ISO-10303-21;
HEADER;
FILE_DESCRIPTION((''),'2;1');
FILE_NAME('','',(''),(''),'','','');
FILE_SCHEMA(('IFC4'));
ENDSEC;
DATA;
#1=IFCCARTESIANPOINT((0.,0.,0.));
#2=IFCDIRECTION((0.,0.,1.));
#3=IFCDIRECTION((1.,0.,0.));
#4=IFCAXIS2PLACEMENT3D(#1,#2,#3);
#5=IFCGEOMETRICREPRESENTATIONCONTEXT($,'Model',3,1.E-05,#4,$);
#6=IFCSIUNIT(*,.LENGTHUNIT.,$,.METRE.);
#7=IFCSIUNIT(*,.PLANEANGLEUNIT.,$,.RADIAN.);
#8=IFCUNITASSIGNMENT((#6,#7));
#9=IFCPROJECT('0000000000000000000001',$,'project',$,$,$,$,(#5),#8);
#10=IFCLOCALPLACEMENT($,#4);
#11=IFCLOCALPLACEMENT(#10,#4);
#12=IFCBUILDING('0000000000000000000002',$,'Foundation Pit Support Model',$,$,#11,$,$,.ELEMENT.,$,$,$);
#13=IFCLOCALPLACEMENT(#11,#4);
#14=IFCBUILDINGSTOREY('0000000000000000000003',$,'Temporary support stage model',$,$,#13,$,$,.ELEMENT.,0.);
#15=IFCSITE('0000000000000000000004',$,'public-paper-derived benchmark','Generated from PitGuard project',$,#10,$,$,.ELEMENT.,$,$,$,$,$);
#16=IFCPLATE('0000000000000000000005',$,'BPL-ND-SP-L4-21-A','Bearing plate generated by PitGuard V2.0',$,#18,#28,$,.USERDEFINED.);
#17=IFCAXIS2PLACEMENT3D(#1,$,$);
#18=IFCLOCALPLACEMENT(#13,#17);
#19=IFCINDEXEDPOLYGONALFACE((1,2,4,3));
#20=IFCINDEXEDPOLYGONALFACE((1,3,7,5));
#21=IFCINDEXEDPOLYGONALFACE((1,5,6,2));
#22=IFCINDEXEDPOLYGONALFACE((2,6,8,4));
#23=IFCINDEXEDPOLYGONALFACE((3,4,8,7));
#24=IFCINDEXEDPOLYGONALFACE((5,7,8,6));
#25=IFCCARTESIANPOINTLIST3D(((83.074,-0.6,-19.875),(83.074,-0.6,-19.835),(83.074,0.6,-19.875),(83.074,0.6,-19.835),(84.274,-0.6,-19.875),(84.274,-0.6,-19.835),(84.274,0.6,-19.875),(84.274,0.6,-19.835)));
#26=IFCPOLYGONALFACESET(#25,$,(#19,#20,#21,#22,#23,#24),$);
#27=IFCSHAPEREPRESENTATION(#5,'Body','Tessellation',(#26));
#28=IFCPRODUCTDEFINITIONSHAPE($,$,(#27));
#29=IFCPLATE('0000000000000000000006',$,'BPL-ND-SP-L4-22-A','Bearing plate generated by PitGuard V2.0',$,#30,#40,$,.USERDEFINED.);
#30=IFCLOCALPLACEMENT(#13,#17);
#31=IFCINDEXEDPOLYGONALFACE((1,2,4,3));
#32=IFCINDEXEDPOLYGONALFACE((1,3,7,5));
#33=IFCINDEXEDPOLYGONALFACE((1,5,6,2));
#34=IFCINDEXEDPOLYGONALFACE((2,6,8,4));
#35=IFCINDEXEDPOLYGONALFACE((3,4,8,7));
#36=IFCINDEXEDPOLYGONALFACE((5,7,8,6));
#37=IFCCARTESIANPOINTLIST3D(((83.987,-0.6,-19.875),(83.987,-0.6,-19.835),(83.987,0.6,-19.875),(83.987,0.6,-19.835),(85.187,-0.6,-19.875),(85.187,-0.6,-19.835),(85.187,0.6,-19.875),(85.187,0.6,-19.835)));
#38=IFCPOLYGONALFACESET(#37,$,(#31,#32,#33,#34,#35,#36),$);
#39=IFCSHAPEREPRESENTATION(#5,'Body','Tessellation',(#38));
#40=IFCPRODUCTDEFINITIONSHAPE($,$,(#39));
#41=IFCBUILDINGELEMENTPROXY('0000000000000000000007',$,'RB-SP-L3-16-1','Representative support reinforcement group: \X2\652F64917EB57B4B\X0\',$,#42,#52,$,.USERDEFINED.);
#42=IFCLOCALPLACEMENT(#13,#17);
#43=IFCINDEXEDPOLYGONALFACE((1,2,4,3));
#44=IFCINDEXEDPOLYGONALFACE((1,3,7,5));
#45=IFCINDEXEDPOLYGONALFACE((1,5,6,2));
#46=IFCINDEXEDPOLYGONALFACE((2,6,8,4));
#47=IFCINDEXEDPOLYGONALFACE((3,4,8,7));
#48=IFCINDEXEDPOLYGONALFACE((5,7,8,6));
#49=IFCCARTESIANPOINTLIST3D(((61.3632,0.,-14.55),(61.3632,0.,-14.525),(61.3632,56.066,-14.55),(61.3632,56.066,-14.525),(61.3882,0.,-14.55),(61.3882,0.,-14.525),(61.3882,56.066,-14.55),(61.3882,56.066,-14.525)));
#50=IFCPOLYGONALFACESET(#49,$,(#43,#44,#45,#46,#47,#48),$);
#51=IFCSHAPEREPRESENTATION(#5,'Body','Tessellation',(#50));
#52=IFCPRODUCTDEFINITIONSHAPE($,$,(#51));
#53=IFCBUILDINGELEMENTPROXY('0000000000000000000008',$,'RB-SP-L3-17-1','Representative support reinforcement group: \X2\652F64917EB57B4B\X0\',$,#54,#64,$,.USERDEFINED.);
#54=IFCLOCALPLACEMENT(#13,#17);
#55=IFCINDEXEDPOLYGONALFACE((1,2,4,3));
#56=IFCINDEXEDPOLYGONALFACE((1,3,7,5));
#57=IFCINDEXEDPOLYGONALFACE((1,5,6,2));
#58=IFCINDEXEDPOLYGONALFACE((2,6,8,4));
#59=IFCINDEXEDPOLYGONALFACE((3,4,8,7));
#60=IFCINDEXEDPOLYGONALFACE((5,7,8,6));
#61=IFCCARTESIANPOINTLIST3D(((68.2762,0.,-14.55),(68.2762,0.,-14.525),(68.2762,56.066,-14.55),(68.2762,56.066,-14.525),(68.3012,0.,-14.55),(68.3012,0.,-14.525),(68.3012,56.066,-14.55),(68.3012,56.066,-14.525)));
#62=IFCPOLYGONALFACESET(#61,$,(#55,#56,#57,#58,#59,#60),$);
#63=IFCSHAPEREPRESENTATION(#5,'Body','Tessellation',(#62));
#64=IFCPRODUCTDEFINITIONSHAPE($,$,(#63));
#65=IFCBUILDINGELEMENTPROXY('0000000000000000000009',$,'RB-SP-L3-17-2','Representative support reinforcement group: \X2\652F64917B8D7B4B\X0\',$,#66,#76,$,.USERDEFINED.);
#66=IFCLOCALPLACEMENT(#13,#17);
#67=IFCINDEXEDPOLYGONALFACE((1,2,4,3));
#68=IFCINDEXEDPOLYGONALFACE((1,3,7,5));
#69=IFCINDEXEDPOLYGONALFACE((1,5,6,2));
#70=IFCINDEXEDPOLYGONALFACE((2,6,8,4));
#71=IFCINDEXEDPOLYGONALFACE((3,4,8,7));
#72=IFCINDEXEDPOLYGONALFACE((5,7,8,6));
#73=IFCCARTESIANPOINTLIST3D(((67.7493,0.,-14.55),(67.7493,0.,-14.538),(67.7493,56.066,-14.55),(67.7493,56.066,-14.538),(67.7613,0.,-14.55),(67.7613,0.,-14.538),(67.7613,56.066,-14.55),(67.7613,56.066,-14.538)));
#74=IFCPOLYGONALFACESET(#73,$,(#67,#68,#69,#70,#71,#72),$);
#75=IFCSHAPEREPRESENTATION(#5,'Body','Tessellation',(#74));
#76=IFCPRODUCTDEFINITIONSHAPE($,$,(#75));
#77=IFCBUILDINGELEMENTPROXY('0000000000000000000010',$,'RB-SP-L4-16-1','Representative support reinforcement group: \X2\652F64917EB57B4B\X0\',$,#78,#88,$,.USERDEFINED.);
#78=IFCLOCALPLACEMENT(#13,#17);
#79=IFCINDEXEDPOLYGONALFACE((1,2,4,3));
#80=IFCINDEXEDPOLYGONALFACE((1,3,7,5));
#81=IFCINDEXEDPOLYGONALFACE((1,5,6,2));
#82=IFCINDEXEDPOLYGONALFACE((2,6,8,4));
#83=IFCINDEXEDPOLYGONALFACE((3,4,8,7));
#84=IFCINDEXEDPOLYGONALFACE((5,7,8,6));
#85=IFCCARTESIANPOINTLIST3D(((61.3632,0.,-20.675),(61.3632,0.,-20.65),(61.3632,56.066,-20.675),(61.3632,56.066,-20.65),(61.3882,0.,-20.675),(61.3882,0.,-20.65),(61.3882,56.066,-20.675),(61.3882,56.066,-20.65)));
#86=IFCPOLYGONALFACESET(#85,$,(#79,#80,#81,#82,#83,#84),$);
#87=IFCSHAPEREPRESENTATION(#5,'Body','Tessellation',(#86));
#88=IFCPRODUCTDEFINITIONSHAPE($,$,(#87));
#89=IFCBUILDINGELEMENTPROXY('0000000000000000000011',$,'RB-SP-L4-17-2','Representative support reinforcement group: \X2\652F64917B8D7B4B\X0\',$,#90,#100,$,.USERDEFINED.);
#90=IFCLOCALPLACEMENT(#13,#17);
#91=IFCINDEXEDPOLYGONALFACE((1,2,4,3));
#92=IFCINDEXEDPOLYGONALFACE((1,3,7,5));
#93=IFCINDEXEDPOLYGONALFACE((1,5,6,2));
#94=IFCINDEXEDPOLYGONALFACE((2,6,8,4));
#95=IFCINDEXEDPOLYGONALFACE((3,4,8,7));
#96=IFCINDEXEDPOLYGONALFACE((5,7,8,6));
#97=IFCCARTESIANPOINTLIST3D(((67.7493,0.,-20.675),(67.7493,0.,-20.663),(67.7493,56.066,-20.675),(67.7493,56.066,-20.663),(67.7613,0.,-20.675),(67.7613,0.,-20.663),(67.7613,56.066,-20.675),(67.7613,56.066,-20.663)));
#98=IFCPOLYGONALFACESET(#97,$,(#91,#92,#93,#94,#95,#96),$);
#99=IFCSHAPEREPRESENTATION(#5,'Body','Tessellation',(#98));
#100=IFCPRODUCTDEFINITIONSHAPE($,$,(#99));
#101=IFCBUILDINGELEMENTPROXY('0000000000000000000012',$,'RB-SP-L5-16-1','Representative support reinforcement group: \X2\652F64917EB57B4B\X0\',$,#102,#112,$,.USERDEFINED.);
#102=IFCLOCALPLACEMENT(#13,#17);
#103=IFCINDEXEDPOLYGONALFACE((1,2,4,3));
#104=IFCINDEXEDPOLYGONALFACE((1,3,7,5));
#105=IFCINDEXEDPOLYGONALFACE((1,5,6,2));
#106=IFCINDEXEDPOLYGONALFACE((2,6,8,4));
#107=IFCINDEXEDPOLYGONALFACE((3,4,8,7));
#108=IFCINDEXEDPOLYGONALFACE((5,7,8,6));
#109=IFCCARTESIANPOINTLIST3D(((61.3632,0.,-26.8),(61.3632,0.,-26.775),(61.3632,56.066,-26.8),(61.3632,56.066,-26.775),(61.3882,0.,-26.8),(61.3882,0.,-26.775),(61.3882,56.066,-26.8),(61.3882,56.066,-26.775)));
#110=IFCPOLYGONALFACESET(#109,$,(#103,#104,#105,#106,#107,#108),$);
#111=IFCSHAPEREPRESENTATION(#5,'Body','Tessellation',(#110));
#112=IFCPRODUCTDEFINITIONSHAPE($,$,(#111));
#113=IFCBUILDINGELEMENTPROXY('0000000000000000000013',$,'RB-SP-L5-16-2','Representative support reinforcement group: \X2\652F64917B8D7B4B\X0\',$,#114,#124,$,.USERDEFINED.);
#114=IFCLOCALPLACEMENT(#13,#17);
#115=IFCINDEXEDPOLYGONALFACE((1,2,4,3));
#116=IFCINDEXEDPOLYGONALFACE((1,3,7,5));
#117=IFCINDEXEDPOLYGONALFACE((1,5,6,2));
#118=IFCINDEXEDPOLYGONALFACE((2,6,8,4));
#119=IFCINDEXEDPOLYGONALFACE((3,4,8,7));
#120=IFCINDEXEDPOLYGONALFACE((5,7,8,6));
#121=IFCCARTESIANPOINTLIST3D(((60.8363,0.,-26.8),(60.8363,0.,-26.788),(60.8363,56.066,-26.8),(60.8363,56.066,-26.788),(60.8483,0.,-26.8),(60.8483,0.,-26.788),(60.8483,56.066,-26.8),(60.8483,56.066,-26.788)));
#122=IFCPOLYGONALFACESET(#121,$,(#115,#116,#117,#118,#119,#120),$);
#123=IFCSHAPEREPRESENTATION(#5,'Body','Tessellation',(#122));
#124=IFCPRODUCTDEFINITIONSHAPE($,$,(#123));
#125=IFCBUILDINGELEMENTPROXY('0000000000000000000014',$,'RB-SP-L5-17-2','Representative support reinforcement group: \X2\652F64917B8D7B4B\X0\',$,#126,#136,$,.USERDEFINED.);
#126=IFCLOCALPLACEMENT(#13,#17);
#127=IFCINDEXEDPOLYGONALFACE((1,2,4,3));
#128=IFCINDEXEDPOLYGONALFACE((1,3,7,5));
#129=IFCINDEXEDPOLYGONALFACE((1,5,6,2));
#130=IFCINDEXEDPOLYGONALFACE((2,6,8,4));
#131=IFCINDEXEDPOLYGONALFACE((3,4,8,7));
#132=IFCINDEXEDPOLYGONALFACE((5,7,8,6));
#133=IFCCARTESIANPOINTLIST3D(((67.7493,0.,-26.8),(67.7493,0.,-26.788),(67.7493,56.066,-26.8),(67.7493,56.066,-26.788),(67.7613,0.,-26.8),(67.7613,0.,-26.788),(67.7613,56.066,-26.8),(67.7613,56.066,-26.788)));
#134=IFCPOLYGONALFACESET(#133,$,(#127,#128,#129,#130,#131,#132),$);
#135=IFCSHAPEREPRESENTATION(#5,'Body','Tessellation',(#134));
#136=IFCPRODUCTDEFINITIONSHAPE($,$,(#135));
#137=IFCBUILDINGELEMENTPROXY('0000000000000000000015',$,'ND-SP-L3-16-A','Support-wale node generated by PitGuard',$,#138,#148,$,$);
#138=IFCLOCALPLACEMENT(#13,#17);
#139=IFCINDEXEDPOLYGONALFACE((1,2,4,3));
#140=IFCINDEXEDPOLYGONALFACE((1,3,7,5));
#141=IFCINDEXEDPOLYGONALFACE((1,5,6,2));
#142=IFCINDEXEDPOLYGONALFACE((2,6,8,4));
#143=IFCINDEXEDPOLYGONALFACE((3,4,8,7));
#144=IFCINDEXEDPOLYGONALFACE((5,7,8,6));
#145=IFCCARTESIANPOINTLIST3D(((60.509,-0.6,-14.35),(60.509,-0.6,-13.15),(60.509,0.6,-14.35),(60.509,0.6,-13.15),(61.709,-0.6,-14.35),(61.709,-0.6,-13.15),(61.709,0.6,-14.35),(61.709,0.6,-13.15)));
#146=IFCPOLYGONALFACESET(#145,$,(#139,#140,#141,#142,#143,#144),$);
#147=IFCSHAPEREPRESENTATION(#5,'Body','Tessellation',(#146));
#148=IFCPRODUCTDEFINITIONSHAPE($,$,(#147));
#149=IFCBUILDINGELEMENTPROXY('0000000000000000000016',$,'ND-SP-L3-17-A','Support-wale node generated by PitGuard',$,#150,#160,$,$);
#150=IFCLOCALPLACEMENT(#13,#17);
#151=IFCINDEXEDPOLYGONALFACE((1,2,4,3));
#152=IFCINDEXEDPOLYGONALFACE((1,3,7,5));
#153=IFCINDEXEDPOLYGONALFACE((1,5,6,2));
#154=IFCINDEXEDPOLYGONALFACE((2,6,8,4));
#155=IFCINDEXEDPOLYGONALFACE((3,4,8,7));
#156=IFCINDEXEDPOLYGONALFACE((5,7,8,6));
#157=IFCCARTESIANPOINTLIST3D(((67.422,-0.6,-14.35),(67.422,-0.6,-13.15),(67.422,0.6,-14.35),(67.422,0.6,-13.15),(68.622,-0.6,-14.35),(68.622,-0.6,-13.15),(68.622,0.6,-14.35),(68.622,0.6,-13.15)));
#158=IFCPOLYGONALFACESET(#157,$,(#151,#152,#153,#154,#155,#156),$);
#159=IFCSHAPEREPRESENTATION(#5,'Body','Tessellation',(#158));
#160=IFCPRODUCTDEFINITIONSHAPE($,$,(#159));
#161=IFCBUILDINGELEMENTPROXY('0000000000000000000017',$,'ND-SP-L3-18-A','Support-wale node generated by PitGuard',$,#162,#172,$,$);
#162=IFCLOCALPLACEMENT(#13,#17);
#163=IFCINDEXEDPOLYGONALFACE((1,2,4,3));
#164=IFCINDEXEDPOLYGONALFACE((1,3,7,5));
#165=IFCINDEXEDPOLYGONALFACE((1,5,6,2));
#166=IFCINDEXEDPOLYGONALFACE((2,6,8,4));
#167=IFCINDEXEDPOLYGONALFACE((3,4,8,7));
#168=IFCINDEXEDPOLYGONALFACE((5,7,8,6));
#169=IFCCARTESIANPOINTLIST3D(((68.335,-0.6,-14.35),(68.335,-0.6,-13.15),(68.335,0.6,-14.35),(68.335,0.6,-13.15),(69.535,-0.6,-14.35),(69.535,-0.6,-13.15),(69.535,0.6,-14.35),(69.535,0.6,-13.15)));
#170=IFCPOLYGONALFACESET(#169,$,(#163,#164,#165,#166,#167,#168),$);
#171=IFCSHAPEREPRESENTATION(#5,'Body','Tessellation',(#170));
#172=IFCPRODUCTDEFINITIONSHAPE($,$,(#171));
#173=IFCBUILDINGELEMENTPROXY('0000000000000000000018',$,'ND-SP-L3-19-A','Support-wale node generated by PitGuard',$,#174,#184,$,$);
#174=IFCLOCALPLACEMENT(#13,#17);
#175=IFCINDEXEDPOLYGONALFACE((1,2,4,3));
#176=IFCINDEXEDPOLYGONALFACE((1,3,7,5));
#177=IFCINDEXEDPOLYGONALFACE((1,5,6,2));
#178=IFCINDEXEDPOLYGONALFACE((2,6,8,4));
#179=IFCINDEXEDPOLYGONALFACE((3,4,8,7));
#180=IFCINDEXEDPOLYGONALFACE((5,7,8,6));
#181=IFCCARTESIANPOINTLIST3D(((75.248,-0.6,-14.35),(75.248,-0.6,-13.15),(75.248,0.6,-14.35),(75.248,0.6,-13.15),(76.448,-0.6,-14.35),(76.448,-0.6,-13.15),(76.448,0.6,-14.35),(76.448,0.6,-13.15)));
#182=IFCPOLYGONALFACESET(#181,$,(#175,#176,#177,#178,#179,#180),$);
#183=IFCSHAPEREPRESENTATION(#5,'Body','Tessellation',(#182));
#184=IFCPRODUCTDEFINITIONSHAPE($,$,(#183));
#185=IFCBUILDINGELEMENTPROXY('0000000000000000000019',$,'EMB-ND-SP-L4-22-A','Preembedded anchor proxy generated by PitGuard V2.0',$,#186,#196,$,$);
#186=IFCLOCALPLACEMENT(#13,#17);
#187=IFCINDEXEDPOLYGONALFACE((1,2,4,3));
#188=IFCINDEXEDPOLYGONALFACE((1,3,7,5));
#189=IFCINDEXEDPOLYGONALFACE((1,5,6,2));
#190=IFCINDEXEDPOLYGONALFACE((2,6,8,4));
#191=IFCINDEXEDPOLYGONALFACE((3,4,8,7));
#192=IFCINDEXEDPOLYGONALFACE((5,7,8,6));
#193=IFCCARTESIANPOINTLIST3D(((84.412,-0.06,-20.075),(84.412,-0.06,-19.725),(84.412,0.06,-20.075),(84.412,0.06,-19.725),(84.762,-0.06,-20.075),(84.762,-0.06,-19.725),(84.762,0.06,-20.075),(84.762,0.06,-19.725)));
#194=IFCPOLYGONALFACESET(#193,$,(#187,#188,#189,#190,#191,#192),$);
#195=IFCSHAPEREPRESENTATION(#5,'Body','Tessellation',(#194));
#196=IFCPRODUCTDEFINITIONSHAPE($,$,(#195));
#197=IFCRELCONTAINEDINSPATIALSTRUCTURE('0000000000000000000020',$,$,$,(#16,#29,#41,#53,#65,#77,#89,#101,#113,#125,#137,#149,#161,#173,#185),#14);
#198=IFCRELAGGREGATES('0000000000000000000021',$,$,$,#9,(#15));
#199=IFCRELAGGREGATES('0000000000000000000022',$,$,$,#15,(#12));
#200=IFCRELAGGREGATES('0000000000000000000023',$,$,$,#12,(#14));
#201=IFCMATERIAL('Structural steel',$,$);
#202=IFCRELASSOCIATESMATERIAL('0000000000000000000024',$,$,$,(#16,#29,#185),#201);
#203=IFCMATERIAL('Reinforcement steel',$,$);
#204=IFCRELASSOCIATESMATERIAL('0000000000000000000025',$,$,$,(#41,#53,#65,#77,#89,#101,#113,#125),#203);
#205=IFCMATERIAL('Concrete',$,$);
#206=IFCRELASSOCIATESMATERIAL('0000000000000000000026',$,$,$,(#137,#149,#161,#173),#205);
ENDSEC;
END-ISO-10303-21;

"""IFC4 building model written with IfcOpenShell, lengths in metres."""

from ifc_helpers import new_model, si_unit, frame, origin_with_axes, origin_2d, place, context, project, spatial, rectangle, extrude, material, element, save


model = new_model("IFC4")

# Units and contexts
model_context = context("Model", 3, precision=1e-05, world=origin_with_axes())
ifc_project = project(units=[si_unit("LENGTHUNIT", "METRE"), si_unit("PLANEANGLEUNIT", "RADIAN")], contexts=[model_context])

# Site, building, storey
site_placement = place(None, origin_with_axes())
site = spatial("IfcSite", under=ifc_project, at=site_placement, Name="public-paper-derived benchmark", Description="Generated from PitGuard project", CompositionType="ELEMENT")
building_placement = place(site_placement, origin_with_axes())
building = spatial("IfcBuilding", under=site, at=building_placement, Name="Foundation Pit Support Model", CompositionType="ELEMENT")
storey_placement = place(building_placement, origin_with_axes())
storey = spatial("IfcBuildingStorey", under=building, at=storey_placement, Name="Temporary support stage model", CompositionType="ELEMENT", Elevation=0.0)

# Shared definitions
ifc_material_1 = material(Name="Structural steel")

# Shared definitions
ifc_material_2 = material(Name="Concrete")

# Plates
for number, where, z_axis, x_axis, name in (
    (1, (83.674, 0.0, -19.875), (0.0, 0.0, 1.0), (1.0, 0.0, 0.0), "BPL-ND-SP-L4-21-A"),
    (2, (84.587, 0.0, -19.875), (0.0, 0.0, 1.0), (1.0, 0.0, 0.0), "BPL-ND-SP-L4-22-A"),
):
    element("IfcPlate", number, at=place(storey_placement, frame(where, z_axis=z_axis, x_axis=x_axis)), inside=storey, material=ifc_material_1, Name=name, Description="Bearing plate generated by PitGuard V2.0", PredefinedType="USERDEFINED", context=model_context, shape_type="SweptSolid", body=[
        extrude(rectangle(XDim=1.2, YDim=1.2, at=origin_2d()), origin_with_axes(), (0.0, 0.0, 1.0), 0.04),
    ])

# Building element proxies
ifc_material_3 = material(Name="Reinforcement steel")
for number, where, z_axis, x_axis, name in (
    (3, (61.3757, 28.033, -14.55), (0.0, 0.0, 1.0), (0.0, 1.0, 0.0), "RB-SP-L3-16-1"),
    (4, (68.2887, 28.033, -14.55), (0.0, 0.0, 1.0), (0.0, 1.0, 0.0), "RB-SP-L3-17-1"),
):
    element("IfcBuildingElementProxy", number, at=place(storey_placement, frame(where, z_axis=z_axis, x_axis=x_axis)), inside=storey, material=ifc_material_3, Name=name, Description="Representative support reinforcement group: 支撑纵筋", PredefinedType="USERDEFINED", context=model_context, shape_type="SweptSolid", body=[
        extrude(rectangle(XDim=56.066, YDim=0.025, at=origin_2d()), origin_with_axes(), (0.0, 0.0, 1.0), 0.025),
    ])
proxy_1_placement = place(storey_placement, frame((67.7553, 28.033, -14.55), z_axis=(0.0, 0.0, 1.0), x_axis=(0.0, 1.0, 0.0)))
element("IfcBuildingElementProxy", 5, at=proxy_1_placement, inside=storey, material=ifc_material_3, Name="RB-SP-L3-17-2", Description="Representative support reinforcement group: 支撑箍筋", PredefinedType="USERDEFINED", context=model_context, shape_type="SweptSolid", body=[
    extrude(rectangle(XDim=56.066, YDim=0.012, at=origin_2d()), origin_with_axes(), (0.0, 0.0, 1.0), 0.012),
])
proxy_2_placement = place(storey_placement, frame((61.3757, 28.033, -20.675), z_axis=(0.0, 0.0, 1.0), x_axis=(0.0, 1.0, 0.0)))
element("IfcBuildingElementProxy", 6, at=proxy_2_placement, inside=storey, material=ifc_material_3, Name="RB-SP-L4-16-1", Description="Representative support reinforcement group: 支撑纵筋", PredefinedType="USERDEFINED", context=model_context, shape_type="SweptSolid", body=[
    extrude(rectangle(XDim=56.066, YDim=0.025, at=origin_2d()), origin_with_axes(), (0.0, 0.0, 1.0), 0.025),
])
proxy_3_placement = place(storey_placement, frame((67.7553, 28.033, -20.675), z_axis=(0.0, 0.0, 1.0), x_axis=(0.0, 1.0, 0.0)))
element("IfcBuildingElementProxy", 7, at=proxy_3_placement, inside=storey, material=ifc_material_3, Name="RB-SP-L4-17-2", Description="Representative support reinforcement group: 支撑箍筋", PredefinedType="USERDEFINED", context=model_context, shape_type="SweptSolid", body=[
    extrude(rectangle(XDim=56.066, YDim=0.012, at=origin_2d()), origin_with_axes(), (0.0, 0.0, 1.0), 0.012),
])
proxy_4_placement = place(storey_placement, frame((61.3757, 28.033, -26.8), z_axis=(0.0, 0.0, 1.0), x_axis=(0.0, 1.0, 0.0)))
element("IfcBuildingElementProxy", 8, at=proxy_4_placement, inside=storey, material=ifc_material_3, Name="RB-SP-L5-16-1", Description="Representative support reinforcement group: 支撑纵筋", PredefinedType="USERDEFINED", context=model_context, shape_type="SweptSolid", body=[
    extrude(rectangle(XDim=56.066, YDim=0.025, at=origin_2d()), origin_with_axes(), (0.0, 0.0, 1.0), 0.025),
])
for number, where, z_axis, x_axis, name in (
    (9, (60.8423, 28.033, -26.8), (0.0, 0.0, 1.0), (0.0, 1.0, 0.0), "RB-SP-L5-16-2"),
    (10, (67.7553, 28.033, -26.8), (0.0, 0.0, 1.0), (0.0, 1.0, 0.0), "RB-SP-L5-17-2"),
):
    element("IfcBuildingElementProxy", number, at=place(storey_placement, frame(where, z_axis=z_axis, x_axis=x_axis)), inside=storey, material=ifc_material_3, Name=name, Description="Representative support reinforcement group: 支撑箍筋", PredefinedType="USERDEFINED", context=model_context, shape_type="SweptSolid", body=[
        extrude(rectangle(XDim=56.066, YDim=0.012, at=origin_2d()), origin_with_axes(), (0.0, 0.0, 1.0), 0.012),
    ])
for number, where, z_axis, x_axis, name in (
    (11, (61.109, 0.0, -14.35), (0.0, 0.0, 1.0), (1.0, 0.0, 0.0), "ND-SP-L3-16-A"),
    (12, (68.022, 0.0, -14.35), (0.0, 0.0, 1.0), (1.0, 0.0, 0.0), "ND-SP-L3-17-A"),
    (13, (68.935, 0.0, -14.35), (0.0, 0.0, 1.0), (1.0, 0.0, 0.0), "ND-SP-L3-18-A"),
    (14, (75.848, 0.0, -14.35), (0.0, 0.0, 1.0), (1.0, 0.0, 0.0), "ND-SP-L3-19-A"),
):
    element("IfcBuildingElementProxy", number, at=place(storey_placement, frame(where, z_axis=z_axis, x_axis=x_axis)), inside=storey, material=ifc_material_2, Name=name, Description="Support-wale node generated by PitGuard", context=model_context, shape_type="SweptSolid", body=[
        extrude(rectangle(XDim=1.2, YDim=1.2, at=origin_2d()), origin_with_axes(), (0.0, 0.0, 1.0), 1.2),
    ])
proxy_5_placement = place(storey_placement, frame((84.587, 0.0, -20.075), z_axis=(0.0, 0.0, 1.0), x_axis=(1.0, 0.0, 0.0)))
element("IfcBuildingElementProxy", 15, at=proxy_5_placement, inside=storey, material=ifc_material_1, Name="EMB-ND-SP-L4-22-A", Description="Preembedded anchor proxy generated by PitGuard V2.0", context=model_context, shape_type="SweptSolid", body=[
    extrude(rectangle(XDim=0.35, YDim=0.12, at=origin_2d()), origin_with_axes(), (0.0, 0.0, 1.0), 0.35),
])

save(model, "model.ifc")
